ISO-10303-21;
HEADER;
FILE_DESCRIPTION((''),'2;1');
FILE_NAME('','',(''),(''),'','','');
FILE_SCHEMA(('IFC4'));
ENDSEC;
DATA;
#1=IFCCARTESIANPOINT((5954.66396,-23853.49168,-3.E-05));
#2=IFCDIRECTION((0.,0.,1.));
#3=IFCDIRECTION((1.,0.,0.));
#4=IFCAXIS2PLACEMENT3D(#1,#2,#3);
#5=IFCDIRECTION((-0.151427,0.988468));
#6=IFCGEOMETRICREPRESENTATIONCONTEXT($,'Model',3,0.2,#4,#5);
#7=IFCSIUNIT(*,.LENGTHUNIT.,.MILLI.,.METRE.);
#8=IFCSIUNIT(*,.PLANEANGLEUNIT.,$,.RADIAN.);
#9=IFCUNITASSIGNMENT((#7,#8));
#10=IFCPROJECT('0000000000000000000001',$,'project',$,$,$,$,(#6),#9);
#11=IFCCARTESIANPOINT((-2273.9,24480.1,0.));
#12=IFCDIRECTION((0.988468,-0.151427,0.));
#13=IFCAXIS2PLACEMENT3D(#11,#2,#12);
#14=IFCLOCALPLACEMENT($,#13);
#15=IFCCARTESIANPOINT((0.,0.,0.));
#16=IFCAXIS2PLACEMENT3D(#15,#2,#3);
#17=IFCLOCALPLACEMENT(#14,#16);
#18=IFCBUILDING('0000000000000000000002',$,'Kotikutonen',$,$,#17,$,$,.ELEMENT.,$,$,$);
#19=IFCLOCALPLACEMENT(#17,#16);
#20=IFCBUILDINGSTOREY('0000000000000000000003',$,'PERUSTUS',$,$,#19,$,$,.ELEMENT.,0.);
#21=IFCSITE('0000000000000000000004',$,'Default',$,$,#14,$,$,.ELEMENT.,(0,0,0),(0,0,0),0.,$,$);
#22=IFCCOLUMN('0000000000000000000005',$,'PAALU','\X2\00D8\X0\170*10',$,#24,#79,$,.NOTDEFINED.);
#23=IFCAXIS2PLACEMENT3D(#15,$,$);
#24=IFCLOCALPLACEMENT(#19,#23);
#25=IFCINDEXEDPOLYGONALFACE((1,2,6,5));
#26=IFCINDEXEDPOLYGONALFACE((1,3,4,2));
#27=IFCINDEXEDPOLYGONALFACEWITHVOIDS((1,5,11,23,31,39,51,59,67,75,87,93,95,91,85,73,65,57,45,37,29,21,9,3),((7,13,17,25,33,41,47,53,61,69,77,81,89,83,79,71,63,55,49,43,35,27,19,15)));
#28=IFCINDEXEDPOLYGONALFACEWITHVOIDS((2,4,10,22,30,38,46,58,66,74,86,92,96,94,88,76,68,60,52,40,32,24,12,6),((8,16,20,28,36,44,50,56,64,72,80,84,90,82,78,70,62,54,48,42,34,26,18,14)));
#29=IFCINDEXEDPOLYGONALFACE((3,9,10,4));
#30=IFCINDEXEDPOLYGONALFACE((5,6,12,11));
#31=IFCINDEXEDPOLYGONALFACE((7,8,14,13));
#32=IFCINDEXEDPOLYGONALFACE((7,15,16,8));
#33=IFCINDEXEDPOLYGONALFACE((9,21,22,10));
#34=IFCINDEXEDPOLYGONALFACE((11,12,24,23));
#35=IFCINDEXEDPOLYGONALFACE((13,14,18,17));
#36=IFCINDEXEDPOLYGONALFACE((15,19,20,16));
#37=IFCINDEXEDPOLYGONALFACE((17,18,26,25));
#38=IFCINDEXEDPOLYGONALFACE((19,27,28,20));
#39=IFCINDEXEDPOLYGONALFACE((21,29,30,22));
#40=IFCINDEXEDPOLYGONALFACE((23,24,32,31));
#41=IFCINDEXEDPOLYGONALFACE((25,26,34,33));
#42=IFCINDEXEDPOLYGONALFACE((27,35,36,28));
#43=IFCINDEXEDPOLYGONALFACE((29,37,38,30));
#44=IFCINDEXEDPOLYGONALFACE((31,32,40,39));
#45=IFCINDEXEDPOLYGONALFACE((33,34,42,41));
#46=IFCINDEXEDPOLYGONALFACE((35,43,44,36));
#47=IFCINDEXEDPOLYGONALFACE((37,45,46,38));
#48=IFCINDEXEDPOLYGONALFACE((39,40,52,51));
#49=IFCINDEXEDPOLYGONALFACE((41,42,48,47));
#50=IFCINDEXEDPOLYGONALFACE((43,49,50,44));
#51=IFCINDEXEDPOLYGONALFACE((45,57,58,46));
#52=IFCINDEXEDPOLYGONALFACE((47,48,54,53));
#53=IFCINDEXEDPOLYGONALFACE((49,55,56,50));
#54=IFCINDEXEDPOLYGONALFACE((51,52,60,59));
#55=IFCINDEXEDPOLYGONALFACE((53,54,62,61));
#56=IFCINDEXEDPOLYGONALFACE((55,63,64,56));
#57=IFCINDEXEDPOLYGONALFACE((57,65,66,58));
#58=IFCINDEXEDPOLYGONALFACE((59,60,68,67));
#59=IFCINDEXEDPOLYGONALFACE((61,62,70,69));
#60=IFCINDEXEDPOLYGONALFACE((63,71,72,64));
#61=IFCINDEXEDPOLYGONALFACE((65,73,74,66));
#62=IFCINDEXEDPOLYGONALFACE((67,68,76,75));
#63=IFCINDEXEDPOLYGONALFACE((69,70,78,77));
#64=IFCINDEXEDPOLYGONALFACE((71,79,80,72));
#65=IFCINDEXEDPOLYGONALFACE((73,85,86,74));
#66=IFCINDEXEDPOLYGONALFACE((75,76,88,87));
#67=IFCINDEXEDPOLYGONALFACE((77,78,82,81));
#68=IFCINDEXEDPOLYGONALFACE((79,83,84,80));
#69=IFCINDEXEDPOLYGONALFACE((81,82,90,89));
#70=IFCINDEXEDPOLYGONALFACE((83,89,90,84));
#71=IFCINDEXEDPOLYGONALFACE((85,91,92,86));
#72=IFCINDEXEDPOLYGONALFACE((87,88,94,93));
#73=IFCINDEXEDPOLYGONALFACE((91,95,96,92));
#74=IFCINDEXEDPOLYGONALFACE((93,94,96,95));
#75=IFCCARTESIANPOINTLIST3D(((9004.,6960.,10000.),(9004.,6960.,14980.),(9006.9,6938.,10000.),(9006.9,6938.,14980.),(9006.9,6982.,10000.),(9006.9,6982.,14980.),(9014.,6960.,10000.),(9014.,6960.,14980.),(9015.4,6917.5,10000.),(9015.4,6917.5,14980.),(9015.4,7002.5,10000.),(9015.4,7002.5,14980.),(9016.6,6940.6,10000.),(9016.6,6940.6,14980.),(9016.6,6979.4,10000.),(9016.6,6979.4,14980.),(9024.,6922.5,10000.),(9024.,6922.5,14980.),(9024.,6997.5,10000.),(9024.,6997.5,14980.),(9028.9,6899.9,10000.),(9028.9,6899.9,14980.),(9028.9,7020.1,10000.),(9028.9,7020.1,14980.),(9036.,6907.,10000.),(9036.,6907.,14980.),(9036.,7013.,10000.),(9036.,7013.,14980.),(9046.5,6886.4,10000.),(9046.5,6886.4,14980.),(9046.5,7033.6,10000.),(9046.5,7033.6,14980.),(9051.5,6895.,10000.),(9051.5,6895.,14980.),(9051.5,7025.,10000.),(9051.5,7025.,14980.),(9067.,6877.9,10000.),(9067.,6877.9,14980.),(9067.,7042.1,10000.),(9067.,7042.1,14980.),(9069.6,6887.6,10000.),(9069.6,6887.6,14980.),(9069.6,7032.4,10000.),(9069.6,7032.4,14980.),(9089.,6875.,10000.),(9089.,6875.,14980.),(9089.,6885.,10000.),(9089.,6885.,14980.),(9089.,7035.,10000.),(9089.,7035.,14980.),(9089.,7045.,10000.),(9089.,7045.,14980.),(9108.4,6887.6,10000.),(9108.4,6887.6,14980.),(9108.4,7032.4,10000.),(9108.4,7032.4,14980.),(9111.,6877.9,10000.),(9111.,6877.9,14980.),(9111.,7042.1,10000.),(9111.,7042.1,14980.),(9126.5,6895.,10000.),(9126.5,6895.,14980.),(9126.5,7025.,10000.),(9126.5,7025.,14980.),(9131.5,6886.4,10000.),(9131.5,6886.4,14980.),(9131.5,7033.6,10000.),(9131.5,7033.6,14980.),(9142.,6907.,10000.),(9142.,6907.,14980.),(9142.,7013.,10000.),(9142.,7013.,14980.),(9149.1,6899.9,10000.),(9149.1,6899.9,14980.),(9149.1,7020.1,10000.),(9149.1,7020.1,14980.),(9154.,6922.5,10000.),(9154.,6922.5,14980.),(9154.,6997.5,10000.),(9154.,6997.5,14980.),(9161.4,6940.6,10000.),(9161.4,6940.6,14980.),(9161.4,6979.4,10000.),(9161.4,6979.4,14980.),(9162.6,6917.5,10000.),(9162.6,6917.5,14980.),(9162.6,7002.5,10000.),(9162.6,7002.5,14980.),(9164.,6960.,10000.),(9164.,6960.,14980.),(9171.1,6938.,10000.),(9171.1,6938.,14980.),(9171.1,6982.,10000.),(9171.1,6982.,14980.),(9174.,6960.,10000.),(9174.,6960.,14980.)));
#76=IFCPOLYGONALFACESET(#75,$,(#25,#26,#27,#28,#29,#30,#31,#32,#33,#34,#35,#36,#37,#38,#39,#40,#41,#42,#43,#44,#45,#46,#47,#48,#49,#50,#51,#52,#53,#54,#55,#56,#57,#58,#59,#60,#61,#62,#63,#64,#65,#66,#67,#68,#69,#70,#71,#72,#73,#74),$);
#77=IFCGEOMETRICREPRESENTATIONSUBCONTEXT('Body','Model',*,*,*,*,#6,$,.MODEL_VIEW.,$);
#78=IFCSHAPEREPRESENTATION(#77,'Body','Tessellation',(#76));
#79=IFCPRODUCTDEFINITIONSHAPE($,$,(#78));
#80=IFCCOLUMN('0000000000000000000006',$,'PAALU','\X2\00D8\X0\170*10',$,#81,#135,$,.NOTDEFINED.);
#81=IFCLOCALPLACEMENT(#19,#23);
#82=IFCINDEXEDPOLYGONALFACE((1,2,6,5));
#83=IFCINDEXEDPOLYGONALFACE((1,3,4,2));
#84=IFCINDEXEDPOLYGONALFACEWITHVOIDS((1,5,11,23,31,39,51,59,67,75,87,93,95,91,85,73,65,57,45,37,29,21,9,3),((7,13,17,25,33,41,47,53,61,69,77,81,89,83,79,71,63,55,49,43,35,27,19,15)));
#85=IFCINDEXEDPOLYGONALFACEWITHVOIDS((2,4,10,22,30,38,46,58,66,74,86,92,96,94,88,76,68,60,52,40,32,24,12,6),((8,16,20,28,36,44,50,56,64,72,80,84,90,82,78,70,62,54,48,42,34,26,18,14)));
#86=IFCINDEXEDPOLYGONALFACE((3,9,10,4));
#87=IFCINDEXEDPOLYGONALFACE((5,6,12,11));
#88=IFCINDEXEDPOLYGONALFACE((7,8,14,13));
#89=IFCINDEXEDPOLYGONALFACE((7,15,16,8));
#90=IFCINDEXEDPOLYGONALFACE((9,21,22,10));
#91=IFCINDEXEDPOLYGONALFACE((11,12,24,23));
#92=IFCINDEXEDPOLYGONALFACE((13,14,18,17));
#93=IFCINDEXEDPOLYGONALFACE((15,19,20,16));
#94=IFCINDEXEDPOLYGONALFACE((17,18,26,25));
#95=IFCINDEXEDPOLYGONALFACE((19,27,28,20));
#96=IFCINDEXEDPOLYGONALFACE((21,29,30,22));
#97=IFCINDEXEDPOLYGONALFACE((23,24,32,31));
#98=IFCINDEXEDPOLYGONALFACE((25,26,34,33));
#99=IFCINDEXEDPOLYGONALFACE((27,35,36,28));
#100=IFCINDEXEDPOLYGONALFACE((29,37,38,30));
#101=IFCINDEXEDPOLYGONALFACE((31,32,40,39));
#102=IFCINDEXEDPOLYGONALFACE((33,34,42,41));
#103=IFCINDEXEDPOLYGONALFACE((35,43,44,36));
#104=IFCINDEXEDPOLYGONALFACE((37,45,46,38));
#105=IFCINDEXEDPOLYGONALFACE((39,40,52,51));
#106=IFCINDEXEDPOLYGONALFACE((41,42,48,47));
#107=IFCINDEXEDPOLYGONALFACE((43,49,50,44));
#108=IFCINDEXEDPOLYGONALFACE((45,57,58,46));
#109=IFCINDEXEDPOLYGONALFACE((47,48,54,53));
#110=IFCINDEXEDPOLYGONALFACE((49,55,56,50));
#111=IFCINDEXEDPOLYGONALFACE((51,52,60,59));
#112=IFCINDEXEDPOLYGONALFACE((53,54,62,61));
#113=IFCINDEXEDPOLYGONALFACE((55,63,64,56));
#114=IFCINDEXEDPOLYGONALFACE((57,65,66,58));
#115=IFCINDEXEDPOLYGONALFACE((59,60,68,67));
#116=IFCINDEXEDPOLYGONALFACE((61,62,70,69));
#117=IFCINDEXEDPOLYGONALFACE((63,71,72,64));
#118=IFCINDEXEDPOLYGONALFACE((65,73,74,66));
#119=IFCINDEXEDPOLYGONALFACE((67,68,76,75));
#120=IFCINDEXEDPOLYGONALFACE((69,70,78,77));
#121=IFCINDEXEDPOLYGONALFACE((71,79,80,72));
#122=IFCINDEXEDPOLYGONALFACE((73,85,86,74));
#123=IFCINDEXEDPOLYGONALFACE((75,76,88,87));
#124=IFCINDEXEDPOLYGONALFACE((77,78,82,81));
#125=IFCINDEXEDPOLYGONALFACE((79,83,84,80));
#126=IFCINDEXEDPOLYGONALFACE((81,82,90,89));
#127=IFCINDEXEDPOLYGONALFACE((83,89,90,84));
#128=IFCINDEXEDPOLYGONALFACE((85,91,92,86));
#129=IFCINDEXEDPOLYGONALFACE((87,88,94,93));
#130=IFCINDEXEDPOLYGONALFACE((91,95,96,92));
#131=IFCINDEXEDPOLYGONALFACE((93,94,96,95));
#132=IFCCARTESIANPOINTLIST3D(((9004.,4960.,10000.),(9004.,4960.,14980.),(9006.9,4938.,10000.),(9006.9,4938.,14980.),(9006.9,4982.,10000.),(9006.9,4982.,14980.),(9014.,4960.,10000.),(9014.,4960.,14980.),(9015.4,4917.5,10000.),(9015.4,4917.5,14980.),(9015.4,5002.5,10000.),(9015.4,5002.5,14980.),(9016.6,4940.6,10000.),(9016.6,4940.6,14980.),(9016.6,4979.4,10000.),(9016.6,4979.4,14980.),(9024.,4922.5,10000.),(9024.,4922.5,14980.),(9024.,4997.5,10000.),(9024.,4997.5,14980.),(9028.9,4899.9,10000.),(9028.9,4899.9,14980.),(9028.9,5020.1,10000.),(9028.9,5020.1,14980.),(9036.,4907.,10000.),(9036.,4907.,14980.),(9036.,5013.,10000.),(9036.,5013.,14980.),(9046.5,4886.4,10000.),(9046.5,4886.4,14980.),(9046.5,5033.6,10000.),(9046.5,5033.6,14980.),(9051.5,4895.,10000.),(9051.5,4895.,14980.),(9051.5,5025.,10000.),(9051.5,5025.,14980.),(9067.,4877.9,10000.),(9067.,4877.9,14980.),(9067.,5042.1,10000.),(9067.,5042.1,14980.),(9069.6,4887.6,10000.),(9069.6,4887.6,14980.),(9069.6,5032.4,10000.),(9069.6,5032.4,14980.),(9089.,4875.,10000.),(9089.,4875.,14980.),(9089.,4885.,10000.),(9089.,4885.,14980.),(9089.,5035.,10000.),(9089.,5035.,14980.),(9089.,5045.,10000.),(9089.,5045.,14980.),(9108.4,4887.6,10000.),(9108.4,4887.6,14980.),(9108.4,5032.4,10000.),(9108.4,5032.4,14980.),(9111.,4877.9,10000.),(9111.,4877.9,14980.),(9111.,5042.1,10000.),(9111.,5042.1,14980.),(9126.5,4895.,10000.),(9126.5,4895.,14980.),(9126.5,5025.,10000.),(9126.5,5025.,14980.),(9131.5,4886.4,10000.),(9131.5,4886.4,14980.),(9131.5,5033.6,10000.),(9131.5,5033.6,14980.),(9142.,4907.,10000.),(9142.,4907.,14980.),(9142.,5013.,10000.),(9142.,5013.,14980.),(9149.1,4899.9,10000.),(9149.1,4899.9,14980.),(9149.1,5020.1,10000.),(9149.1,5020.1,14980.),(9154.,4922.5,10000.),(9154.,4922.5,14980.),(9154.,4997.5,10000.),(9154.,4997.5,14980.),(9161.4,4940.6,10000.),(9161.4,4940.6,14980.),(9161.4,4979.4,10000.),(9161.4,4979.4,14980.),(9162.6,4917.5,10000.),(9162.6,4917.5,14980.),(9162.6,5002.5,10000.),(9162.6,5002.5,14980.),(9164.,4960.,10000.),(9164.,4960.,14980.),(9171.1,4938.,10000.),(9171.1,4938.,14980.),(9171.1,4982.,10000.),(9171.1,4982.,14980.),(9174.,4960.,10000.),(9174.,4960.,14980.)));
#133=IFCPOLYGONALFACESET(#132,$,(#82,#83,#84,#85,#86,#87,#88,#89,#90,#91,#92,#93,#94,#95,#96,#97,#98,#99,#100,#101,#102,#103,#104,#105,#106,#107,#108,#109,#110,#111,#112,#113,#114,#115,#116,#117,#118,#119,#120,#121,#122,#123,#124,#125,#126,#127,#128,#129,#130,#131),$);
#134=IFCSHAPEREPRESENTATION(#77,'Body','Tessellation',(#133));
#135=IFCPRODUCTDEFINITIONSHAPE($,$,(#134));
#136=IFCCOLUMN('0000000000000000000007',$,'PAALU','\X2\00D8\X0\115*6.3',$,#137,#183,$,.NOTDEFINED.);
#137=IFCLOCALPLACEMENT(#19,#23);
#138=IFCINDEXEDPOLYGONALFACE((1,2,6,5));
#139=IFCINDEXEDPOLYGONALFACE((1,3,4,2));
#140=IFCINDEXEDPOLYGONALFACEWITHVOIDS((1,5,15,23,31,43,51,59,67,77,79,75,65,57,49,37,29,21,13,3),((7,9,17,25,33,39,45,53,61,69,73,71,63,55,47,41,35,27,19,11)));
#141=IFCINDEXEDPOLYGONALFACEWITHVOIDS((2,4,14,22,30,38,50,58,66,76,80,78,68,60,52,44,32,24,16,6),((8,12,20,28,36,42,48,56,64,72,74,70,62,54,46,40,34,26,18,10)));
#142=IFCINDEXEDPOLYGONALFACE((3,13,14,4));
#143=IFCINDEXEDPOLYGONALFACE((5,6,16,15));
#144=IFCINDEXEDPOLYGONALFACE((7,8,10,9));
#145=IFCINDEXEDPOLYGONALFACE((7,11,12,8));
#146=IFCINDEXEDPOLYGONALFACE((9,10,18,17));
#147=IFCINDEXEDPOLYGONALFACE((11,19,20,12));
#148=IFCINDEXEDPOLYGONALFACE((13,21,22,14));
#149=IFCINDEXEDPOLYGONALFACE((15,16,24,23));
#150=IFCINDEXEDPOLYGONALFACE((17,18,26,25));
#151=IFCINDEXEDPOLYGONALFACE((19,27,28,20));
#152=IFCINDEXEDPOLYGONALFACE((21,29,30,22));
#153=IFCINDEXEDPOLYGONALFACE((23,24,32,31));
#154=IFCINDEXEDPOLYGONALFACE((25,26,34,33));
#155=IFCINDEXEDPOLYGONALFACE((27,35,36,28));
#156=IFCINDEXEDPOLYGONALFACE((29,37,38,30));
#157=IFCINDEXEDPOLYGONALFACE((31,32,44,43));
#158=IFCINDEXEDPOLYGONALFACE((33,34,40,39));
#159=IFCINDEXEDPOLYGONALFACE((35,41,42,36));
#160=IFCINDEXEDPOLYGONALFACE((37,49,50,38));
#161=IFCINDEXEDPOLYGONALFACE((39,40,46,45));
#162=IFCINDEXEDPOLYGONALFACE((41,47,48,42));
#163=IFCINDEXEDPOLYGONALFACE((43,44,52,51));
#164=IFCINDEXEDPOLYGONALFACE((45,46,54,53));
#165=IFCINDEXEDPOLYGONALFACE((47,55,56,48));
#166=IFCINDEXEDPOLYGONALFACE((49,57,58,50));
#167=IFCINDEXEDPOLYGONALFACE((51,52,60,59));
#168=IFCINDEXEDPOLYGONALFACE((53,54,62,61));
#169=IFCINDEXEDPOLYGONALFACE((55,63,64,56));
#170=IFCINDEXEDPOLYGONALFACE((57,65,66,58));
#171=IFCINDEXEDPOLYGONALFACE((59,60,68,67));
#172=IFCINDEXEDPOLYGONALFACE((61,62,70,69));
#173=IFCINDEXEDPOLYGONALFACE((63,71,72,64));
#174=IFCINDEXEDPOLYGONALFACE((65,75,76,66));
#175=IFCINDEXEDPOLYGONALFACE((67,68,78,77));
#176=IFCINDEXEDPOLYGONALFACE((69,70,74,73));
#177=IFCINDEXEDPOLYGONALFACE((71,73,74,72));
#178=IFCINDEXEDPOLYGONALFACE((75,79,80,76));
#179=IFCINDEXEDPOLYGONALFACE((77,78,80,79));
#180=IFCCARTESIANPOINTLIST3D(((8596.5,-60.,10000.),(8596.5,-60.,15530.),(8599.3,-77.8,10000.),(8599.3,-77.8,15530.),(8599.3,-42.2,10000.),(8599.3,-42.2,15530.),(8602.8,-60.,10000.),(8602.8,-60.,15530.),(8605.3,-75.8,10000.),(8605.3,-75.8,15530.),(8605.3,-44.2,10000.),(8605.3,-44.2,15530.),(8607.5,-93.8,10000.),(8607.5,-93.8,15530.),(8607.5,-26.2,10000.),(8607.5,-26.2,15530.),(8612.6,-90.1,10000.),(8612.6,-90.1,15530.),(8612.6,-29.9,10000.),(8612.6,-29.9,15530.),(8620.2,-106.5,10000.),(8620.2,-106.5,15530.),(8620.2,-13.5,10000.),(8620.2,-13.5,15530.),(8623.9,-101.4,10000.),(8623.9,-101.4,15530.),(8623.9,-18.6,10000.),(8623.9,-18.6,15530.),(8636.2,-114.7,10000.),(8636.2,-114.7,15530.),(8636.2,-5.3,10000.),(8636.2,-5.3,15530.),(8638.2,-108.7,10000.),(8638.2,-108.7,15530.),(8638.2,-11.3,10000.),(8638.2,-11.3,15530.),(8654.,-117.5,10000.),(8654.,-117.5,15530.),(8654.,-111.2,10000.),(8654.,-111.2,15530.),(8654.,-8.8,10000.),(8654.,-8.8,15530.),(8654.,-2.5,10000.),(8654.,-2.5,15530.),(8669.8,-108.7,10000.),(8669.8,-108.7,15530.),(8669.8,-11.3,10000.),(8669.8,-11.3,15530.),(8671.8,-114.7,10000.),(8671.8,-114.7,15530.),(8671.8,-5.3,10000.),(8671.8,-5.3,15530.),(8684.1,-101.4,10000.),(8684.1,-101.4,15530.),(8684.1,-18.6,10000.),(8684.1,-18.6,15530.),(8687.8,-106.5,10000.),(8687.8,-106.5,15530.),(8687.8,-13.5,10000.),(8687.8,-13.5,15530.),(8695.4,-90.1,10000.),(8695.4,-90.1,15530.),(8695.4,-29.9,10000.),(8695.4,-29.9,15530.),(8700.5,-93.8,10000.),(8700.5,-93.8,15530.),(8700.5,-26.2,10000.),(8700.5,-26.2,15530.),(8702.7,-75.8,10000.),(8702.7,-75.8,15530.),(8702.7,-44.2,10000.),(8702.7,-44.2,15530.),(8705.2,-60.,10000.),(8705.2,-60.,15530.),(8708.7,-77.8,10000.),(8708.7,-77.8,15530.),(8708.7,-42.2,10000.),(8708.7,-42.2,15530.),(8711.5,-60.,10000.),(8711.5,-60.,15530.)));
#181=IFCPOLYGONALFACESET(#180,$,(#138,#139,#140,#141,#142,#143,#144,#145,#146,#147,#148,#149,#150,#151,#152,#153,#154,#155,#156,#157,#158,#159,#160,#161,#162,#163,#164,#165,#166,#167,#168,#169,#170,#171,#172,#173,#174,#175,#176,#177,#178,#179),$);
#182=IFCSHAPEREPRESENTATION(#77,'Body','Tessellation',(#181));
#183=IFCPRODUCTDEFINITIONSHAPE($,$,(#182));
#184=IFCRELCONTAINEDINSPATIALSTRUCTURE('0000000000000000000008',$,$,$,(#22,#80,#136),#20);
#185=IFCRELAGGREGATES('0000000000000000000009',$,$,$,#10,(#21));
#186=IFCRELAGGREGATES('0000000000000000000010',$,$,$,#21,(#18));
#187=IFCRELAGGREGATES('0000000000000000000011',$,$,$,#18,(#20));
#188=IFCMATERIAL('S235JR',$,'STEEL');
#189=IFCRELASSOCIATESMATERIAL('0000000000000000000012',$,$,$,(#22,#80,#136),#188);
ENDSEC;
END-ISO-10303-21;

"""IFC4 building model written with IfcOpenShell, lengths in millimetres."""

from ifc_helpers import new_model, si_unit, direction, frame, origin_with_axes, place, context, subcontext, project, spatial, line, indexed_curve, outline, extrude, material, element, save


model = new_model("IFC4")

# Units and contexts
model_context = context("Model", 3, precision=0.2, world=frame((5954.66396, -23853.49168, -3e-05), z_axis=(0.0, 0.0, 1.0), x_axis=(1.0, 0.0, 0.0)), true_north=direction((-0.151427, 0.988468)))
body_context = subcontext(model_context, "Body", "Model", "MODEL_VIEW")
ifc_project = project(units=[si_unit("LENGTHUNIT", "METRE", prefix="MILLI"), si_unit("PLANEANGLEUNIT", "RADIAN")], contexts=[model_context])

# Site, building, storey
site_placement = place(None, frame((-2273.9, 24480.1, 0.0), z_axis=(0.0, 0.0, 1.0), x_axis=(0.988468, -0.151427, 0.0)))
site = spatial("IfcSite", under=ifc_project, at=site_placement, Name="Default", CompositionType="ELEMENT", RefLatitude=(0, 0, 0), RefLongitude=(0, 0, 0), RefElevation=0.0)
building_placement = place(site_placement, origin_with_axes())
building = spatial("IfcBuilding", under=site, at=building_placement, Name="Kotikutonen", CompositionType="ELEMENT")
storey_placement = place(building_placement, origin_with_axes())
storey = spatial("IfcBuildingStorey", under=building, at=storey_placement, Name="PERUSTUS", CompositionType="ELEMENT", Elevation=0.0)

# Columns
ifc_material = material(Name="S235JR", Category="STEEL")
for number, where, z_axis, x_axis, name in (
    (1, (9089.0, 6960.0, 10000.0), (-1.0, 0.0, 0.0), (0.0, 0.0, 1.0), "PAALU"),
    (2, (9089.0, 4960.0, 10000.0), (-1.0, 0.0, 0.0), (0.0, 0.0, 1.0), "PAALU"),
):
    element("IfcColumn", number, at=place(storey_placement, frame(where, z_axis=z_axis, x_axis=x_axis)), inside=storey, material=ifc_material, Name=name, Description="Ø170*10", PredefinedType="NOTDEFINED", context=body_context, shape_type="SolidModel", body=[
        extrude(outline(indexed_curve([(85.0, 0.0), (82.1, 22.0), (73.6, 42.5), (60.1, 60.1), (42.5, 73.6), (22.0, 82.1), (0.0, 85.0), (-22.0, 82.1), (-42.5, 73.6), (-60.1, 60.1), (-73.6, 42.5), (-82.1, 22.0), (-85.0, 0.0), (-82.1, -22.0), (-73.6, -42.5), (-60.1, -60.1), (-42.5, -73.6), (-22.0, -82.1), (0.0, -85.0), (22.0, -82.1), (42.5, -73.6), (60.1, -60.1), (73.6, -42.5), (82.1, -22.0)], segments=[line(1, 2, 3, 4, 5, 6, 7, 8, 9, 10, 11, 12, 13, 14, 15, 16, 17, 18, 19, 20, 21, 22, 23, 24, 1)]), holes=[indexed_curve([(75.0, 0.0), (72.4, -19.4), (65.0, -37.5), (53.0, -53.0), (37.5, -65.0), (19.4, -72.4), (0.0, -75.0), (-19.4, -72.4), (-37.5, -65.0), (-53.0, -53.0), (-65.0, -37.5), (-72.4, -19.4), (-75.0, 0.0), (-72.4, 19.4), (-65.0, 37.5), (-53.0, 53.0), (-37.5, 65.0), (-19.4, 72.4), (0.0, 75.0), (19.4, 72.4), (37.5, 65.0), (53.0, 53.0), (65.0, 37.5), (72.4, 19.4)], segments=[line(1, 2, 3, 4, 5, 6, 7, 8, 9, 10, 11, 12, 13, 14, 15, 16, 17, 18, 19, 20, 21, 22, 23, 24, 1)])]), frame((0.0, 0.0, 0.0), z_axis=(-1.0, 0.0, 0.0), x_axis=(0.0, 0.0, 1.0)), (0.0, 0.0, -1.0), 4980.0),
    ])
for number, where, z_axis, x_axis, name in (
    (3, (8654.0, -60.0, 10000.0), (-1.0, 0.0, 0.0), (0.0, 0.0, 1.0), "PAALU"),
):
    element("IfcColumn", number, at=place(storey_placement, frame(where, z_axis=z_axis, x_axis=x_axis)), inside=storey, material=ifc_material, Name=name, Description="Ø115*6.3", PredefinedType="NOTDEFINED", context=body_context, shape_type="SolidModel", body=[
        extrude(outline(indexed_curve([(57.5, 0.0), (54.7, 17.8), (46.5, 33.8), (33.8, 46.5), (17.8, 54.7), (0.0, 57.5), (-17.8, 54.7), (-33.8, 46.5), (-46.5, 33.8), (-54.7, 17.8), (-57.5, 0.0), (-54.7, -17.8), (-46.5, -33.8), (-33.8, -46.5), (-17.8, -54.7), (0.0, -57.5), (17.8, -54.7), (33.8, -46.5), (46.5, -33.8), (54.7, -17.8)], segments=[line(1, 2, 3, 4, 5, 6, 7, 8, 9, 10, 11, 12, 13, 14, 15, 16, 17, 18, 19, 20, 1)]), holes=[indexed_curve([(51.2, 0.0), (48.7, -15.8), (41.4, -30.1), (30.1, -41.4), (15.8, -48.7), (0.0, -51.2), (-15.8, -48.7), (-30.1, -41.4), (-41.4, -30.1), (-48.7, -15.8), (-51.2, 0.0), (-48.7, 15.8), (-41.4, 30.1), (-30.1, 41.4), (-15.8, 48.7), (0.0, 51.2), (15.8, 48.7), (30.1, 41.4), (41.4, 30.1), (48.7, 15.8)], segments=[line(1, 2, 3, 4, 5, 6, 7, 8, 9, 10, 11, 12, 13, 14, 15, 16, 17, 18, 19, 20, 1)])]), frame((0.0, 0.0, 0.0), z_axis=(-1.0, 0.0, 0.0), x_axis=(0.0, 0.0, 1.0)), (0.0, 0.0, -1.0), 5530.0),
    ])

save(model, "model.ifc")
